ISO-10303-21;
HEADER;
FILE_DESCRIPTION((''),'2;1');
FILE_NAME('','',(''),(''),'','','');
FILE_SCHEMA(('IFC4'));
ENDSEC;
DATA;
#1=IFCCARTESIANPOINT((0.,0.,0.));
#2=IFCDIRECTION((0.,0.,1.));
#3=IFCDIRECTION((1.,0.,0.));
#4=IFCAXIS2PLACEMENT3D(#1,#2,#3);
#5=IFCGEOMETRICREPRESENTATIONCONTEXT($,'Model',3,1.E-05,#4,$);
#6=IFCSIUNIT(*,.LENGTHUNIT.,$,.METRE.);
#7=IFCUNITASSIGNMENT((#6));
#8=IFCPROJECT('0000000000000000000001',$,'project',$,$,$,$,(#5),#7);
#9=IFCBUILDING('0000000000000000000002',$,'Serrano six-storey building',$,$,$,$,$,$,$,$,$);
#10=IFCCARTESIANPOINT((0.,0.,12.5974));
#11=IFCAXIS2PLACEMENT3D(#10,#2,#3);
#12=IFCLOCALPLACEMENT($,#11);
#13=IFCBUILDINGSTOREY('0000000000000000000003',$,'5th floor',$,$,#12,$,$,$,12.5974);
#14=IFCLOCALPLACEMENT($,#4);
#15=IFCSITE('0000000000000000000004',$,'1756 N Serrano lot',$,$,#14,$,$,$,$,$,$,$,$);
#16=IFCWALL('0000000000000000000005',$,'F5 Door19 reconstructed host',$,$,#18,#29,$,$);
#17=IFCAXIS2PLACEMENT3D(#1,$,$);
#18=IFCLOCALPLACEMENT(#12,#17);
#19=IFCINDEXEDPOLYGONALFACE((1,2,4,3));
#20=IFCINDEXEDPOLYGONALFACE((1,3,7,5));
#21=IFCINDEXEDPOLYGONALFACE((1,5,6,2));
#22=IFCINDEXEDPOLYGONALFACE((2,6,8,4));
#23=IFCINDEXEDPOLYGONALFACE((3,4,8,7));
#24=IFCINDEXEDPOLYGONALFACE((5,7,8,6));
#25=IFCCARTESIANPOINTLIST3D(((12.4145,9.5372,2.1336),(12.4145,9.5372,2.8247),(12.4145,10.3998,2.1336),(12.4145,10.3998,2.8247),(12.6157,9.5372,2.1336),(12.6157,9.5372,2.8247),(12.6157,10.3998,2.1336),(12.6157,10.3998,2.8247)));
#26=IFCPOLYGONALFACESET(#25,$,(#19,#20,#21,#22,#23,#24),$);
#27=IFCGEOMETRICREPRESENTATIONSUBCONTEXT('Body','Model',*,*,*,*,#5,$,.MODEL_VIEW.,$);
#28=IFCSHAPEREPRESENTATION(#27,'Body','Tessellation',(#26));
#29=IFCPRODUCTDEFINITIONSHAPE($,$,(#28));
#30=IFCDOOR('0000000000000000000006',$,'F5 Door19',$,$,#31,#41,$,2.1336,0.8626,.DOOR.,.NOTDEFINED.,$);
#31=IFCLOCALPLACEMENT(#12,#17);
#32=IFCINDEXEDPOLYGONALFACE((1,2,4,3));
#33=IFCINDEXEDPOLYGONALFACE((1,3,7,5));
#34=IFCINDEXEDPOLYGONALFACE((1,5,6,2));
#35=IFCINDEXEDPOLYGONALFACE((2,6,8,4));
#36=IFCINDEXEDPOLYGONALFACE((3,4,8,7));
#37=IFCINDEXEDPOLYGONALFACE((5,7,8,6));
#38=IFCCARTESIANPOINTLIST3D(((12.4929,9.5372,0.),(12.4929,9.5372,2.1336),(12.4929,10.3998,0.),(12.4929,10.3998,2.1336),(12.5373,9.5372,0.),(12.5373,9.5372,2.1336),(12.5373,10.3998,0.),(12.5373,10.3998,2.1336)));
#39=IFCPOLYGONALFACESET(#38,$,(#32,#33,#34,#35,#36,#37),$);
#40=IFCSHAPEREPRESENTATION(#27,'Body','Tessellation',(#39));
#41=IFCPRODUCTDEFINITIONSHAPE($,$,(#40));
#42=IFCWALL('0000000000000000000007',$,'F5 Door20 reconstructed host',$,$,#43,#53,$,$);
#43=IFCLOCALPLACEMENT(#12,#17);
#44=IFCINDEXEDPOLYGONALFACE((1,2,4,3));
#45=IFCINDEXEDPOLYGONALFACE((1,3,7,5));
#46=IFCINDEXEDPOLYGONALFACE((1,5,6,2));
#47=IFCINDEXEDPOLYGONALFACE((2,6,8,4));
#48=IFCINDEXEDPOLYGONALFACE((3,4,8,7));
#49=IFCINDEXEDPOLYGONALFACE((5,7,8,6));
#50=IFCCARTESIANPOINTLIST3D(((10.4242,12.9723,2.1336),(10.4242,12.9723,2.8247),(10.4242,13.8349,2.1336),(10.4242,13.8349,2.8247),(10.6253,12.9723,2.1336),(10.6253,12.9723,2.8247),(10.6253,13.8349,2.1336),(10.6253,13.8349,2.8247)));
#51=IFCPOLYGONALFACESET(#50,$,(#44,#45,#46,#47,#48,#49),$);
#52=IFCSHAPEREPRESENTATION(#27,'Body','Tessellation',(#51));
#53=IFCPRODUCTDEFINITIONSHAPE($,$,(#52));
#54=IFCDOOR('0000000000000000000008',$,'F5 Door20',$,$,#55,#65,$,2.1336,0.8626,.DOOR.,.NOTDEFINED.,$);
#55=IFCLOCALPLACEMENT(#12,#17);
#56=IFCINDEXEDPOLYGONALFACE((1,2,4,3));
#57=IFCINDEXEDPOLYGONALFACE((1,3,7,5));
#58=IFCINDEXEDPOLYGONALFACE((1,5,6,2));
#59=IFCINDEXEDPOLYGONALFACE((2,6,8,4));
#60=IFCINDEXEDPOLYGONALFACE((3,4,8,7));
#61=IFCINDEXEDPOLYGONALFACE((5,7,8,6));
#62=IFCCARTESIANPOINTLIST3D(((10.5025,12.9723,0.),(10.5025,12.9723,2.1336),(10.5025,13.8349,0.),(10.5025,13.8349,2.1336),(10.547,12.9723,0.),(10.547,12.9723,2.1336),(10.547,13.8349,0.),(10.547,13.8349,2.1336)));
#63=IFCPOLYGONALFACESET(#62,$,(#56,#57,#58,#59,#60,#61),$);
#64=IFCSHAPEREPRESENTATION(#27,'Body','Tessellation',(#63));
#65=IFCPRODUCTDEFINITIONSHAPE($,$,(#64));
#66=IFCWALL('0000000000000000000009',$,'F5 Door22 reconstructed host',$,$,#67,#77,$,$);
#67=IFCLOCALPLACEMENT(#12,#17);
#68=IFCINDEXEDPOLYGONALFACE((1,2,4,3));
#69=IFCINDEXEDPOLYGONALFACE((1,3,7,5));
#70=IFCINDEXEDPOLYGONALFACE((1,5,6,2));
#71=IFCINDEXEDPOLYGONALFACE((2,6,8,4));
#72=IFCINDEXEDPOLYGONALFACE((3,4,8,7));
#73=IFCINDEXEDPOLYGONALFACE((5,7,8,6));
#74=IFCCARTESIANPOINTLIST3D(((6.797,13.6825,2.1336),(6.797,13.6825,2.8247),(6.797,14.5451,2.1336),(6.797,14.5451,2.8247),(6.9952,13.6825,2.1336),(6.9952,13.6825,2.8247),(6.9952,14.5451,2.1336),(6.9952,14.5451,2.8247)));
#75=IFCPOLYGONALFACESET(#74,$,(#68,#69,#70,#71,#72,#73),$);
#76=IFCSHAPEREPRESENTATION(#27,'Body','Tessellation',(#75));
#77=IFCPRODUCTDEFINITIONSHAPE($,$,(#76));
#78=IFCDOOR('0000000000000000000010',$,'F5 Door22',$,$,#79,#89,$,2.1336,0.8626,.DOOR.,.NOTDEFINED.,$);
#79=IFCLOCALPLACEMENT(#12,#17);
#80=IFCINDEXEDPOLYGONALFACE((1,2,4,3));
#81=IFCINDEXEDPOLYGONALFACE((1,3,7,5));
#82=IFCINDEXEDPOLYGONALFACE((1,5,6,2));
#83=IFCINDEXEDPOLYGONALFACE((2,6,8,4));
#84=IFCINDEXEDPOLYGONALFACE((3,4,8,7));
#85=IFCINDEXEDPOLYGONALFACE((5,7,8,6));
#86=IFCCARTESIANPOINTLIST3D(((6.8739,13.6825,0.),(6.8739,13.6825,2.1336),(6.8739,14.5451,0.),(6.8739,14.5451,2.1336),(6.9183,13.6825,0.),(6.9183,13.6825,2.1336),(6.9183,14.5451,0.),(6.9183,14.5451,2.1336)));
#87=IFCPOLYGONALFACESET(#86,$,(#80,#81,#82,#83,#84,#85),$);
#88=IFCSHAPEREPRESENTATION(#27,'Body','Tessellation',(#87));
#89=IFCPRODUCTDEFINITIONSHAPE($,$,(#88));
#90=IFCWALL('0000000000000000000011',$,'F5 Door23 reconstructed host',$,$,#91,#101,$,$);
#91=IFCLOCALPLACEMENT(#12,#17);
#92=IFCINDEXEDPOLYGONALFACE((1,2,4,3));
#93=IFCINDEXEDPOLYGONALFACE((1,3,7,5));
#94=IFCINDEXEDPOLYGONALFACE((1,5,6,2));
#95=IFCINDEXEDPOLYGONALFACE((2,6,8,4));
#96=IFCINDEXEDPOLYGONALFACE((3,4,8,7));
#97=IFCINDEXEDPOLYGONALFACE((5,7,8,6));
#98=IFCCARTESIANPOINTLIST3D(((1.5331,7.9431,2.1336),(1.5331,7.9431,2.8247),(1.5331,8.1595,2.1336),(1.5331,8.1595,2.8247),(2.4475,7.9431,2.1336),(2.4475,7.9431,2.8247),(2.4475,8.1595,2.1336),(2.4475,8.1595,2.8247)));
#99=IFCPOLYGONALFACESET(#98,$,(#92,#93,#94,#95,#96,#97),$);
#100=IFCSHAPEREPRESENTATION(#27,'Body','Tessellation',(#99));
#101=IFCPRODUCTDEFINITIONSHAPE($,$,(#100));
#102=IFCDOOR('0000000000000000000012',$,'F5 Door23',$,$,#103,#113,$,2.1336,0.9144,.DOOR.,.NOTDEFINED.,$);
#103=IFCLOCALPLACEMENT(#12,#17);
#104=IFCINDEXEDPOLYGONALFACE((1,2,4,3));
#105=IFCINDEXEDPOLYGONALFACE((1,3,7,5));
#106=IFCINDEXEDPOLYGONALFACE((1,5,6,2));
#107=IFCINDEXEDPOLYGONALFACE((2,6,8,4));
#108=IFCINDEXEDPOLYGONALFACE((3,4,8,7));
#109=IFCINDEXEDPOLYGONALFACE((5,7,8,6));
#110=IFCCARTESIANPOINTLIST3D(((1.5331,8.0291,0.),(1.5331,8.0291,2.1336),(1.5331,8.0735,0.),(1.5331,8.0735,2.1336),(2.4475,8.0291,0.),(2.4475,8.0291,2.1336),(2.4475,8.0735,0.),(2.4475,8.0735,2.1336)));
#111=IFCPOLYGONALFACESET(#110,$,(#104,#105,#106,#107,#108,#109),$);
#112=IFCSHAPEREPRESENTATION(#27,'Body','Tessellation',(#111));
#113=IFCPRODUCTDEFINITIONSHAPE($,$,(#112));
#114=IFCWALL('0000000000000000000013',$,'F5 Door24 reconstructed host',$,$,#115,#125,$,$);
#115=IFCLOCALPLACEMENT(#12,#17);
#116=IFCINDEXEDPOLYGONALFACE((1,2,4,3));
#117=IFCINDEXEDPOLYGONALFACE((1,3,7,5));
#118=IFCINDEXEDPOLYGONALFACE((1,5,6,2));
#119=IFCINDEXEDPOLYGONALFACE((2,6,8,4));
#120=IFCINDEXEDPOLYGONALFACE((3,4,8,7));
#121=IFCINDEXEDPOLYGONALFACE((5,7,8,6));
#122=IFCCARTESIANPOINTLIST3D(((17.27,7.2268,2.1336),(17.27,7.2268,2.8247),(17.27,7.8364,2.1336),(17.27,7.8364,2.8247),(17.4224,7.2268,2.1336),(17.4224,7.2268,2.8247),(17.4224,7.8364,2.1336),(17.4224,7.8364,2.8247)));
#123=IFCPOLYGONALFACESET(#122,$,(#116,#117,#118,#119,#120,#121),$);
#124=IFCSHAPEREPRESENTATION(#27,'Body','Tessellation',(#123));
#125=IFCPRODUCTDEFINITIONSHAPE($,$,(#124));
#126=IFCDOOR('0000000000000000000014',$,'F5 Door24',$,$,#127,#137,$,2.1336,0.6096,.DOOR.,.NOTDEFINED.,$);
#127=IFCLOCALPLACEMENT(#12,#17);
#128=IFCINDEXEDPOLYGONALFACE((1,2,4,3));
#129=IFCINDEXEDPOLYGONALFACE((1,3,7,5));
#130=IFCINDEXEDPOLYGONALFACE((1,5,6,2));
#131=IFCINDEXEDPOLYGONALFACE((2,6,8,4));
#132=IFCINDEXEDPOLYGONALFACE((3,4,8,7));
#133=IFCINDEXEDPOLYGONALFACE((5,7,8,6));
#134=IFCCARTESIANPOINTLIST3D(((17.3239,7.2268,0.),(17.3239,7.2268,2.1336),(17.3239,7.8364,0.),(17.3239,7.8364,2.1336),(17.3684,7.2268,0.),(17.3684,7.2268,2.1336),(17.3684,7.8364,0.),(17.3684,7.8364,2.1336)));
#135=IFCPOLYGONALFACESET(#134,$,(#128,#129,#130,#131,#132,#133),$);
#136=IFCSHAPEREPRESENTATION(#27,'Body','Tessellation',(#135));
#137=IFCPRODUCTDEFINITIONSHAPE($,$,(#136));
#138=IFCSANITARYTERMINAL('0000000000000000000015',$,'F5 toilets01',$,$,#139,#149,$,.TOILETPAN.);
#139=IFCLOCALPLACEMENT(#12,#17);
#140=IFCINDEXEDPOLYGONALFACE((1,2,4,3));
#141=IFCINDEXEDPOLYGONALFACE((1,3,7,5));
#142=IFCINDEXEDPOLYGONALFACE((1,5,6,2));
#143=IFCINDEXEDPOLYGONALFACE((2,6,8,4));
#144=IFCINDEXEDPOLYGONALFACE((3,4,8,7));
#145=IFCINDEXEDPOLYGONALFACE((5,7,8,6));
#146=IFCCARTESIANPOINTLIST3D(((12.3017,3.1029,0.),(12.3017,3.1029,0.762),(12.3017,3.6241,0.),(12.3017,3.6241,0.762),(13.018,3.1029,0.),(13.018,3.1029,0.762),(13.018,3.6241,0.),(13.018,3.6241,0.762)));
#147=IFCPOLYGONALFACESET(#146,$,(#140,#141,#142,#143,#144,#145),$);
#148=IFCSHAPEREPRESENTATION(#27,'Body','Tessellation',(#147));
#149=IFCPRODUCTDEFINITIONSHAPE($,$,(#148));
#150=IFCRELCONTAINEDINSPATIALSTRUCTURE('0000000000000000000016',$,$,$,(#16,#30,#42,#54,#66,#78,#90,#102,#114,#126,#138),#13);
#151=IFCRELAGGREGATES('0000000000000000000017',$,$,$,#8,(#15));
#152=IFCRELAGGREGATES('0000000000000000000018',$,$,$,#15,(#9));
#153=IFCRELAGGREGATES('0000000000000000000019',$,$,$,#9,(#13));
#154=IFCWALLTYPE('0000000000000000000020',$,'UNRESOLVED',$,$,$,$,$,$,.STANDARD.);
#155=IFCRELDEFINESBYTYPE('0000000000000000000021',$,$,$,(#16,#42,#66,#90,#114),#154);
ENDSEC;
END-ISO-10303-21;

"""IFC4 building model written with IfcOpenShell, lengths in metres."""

from ifc_helpers import new_model, si_unit, frame, origin_with_axes, place, context, subcontext, project, spatial, polyline, outline, extrude, type_object, element, fill, save


model = new_model("IFC4")

# Units and contexts
model_context = context("Model", 3, precision=1e-05, world=origin_with_axes())
body_context = subcontext(model_context, "Body", "Model", "MODEL_VIEW")
ifc_project = project(units=[si_unit("LENGTHUNIT", "METRE")], contexts=[model_context])

# Site, building, storey
site_placement = place(None, origin_with_axes())
site = spatial("IfcSite", under=ifc_project, at=site_placement, Name="1756 N Serrano lot")
building = spatial("IfcBuilding", under=site, Name="Serrano six-storey building")
storey_placement = place(None, frame((0.0, 0.0, 12.5974), z_axis=(0.0, 0.0, 1.0), x_axis=(1.0, 0.0, 0.0)))
storey = spatial("IfcBuildingStorey", under=building, at=storey_placement, Name="5th floor", Elevation=12.5974)

# Walls, openings, doors
wall_type_1 = type_object("IfcWallType", Name="UNRESOLVED", PredefinedType="STANDARD")
wall_1_placement = place(storey_placement, frame((0.0, 0.0, -12.5974), z_axis=(0.0, 0.0, 1.0), x_axis=(1.0, 0.0, 0.0)))
wall_1 = element("IfcWall", 1, at=wall_1_placement, inside=storey, type_object=wall_type_1, Name="F5 Door19 reconstructed host", context=body_context, shape_type="SweptSolid", body=[
    extrude(outline(polyline([(12.4145, 10.3998), (12.6157, 10.3998), (12.6157, 9.5372), (12.4145, 9.5372), (12.4145, 10.3998)])), frame((0.0, 0.0, 12.5974)), (0.0, 0.0, 1.0), 2.8247),
])
opening_1_placement = place(None, origin_with_axes())
opening_1 = element("IfcOpeningElement", 2, at=opening_1_placement, cuts=wall_1, PredefinedType="OPENING", context=body_context, shape_type="SweptSolid", body=[
    extrude(outline(polyline([(12.3962, 10.3998), (12.634, 10.3998), (12.634, 9.5372), (12.3962, 9.5372), (12.3962, 10.3998)])), frame((0.0, 0.0, 12.5974)), (0.0, 0.0, 1.0), 2.1336),
])
door_1_placement = place(storey_placement, frame((0.0, 0.0, -12.5974), z_axis=(0.0, 0.0, 1.0), x_axis=(1.0, 0.0, 0.0)))
door_1 = element("IfcDoor", 3, at=door_1_placement, inside=storey, Name="F5 Door19", OperationType="NOTDEFINED", OverallHeight=2.1336, OverallWidth=0.8626, PredefinedType="DOOR", context=body_context, shape_type="SweptSolid", body=[
    extrude(outline(polyline([(12.4929, 10.3998), (12.5373, 10.3998), (12.5373, 9.5372), (12.4929, 9.5372), (12.4929, 10.3998)])), frame((0.0, 0.0, 12.5974)), (0.0, 0.0, 1.0), 2.1336),
])
fill(opening_1, door_1)
wall_2_placement = place(storey_placement, frame((0.0, 0.0, -12.5974), z_axis=(0.0, 0.0, 1.0), x_axis=(1.0, 0.0, 0.0)))
wall_2 = element("IfcWall", 4, at=wall_2_placement, inside=storey, type_object=wall_type_1, Name="F5 Door20 reconstructed host", context=body_context, shape_type="SweptSolid", body=[
    extrude(outline(polyline([(10.6253, 12.9723), (10.4242, 12.9723), (10.4242, 13.8349), (10.6253, 13.8349), (10.6253, 12.9723)])), frame((0.0, 0.0, 12.5974)), (0.0, 0.0, 1.0), 2.8247),
])
opening_2_placement = place(None, origin_with_axes())
opening_2 = element("IfcOpeningElement", 5, at=opening_2_placement, cuts=wall_2, PredefinedType="OPENING", context=body_context, shape_type="SweptSolid", body=[
    extrude(outline(polyline([(10.6436, 12.9723), (10.4059, 12.9723), (10.4059, 13.8349), (10.6436, 13.8349), (10.6436, 12.9723)])), frame((0.0, 0.0, 12.5974)), (0.0, 0.0, 1.0), 2.1336),
])
door_2_placement = place(storey_placement, frame((0.0, 0.0, -12.5974), z_axis=(0.0, 0.0, 1.0), x_axis=(1.0, 0.0, 0.0)))
door_2 = element("IfcDoor", 6, at=door_2_placement, inside=storey, Name="F5 Door20", OperationType="NOTDEFINED", OverallHeight=2.1336, OverallWidth=0.8626, PredefinedType="DOOR", context=body_context, shape_type="SweptSolid", body=[
    extrude(outline(polyline([(10.547, 12.9723), (10.5025, 12.9723), (10.5025, 13.8349), (10.547, 13.8349), (10.547, 12.9723)])), frame((0.0, 0.0, 12.5974)), (0.0, 0.0, 1.0), 2.1336),
])
fill(opening_2, door_2)
wall_3_placement = place(storey_placement, frame((0.0, 0.0, -12.5974), z_axis=(0.0, 0.0, 1.0), x_axis=(1.0, 0.0, 0.0)))
wall_3 = element("IfcWall", 7, at=wall_3_placement, inside=storey, type_object=wall_type_1, Name="F5 Door22 reconstructed host", context=body_context, shape_type="SweptSolid", body=[
    extrude(outline(polyline([(6.9952, 13.6825), (6.797, 13.6825), (6.797, 14.5451), (6.9952, 14.5451), (6.9952, 13.6825)])), frame((0.0, 0.0, 12.5974)), (0.0, 0.0, 1.0), 2.8247),
])
opening_3_placement = place(None, origin_with_axes())
opening_3 = element("IfcOpeningElement", 8, at=opening_3_placement, cuts=wall_3, PredefinedType="OPENING", context=body_context, shape_type="SweptSolid", body=[
    extrude(outline(polyline([(7.0134, 13.6825), (6.7788, 13.6825), (6.7788, 14.5451), (7.0134, 14.5451), (7.0134, 13.6825)])), frame((0.0, 0.0, 12.5974)), (0.0, 0.0, 1.0), 2.1336),
])
door_3_placement = place(storey_placement, frame((0.0, 0.0, -12.5974), z_axis=(0.0, 0.0, 1.0), x_axis=(1.0, 0.0, 0.0)))
door_3 = element("IfcDoor", 9, at=door_3_placement, inside=storey, Name="F5 Door22", OperationType="NOTDEFINED", OverallHeight=2.1336, OverallWidth=0.8626, PredefinedType="DOOR", context=body_context, shape_type="SweptSolid", body=[
    extrude(outline(polyline([(6.9183, 13.6825), (6.8739, 13.6825), (6.8739, 14.5451), (6.9183, 14.5451), (6.9183, 13.6825)])), frame((0.0, 0.0, 12.5974)), (0.0, 0.0, 1.0), 2.1336),
])
fill(opening_3, door_3)
wall_4_placement = place(storey_placement, frame((0.0, 0.0, -12.5974), z_axis=(0.0, 0.0, 1.0), x_axis=(1.0, 0.0, 0.0)))
wall_4 = element("IfcWall", 10, at=wall_4_placement, inside=storey, type_object=wall_type_1, Name="F5 Door23 reconstructed host", context=body_context, shape_type="SweptSolid", body=[
    extrude(outline(polyline([(2.4475, 8.1595), (2.4475, 7.9431), (1.5331, 7.9431), (1.5331, 8.1595), (2.4475, 8.1595)])), frame((0.0, 0.0, 12.5974)), (0.0, 0.0, 1.0), 2.8247),
])
opening_4_placement = place(None, origin_with_axes())
opening_4 = element("IfcOpeningElement", 11, at=opening_4_placement, cuts=wall_4, PredefinedType="OPENING", context=body_context, shape_type="SweptSolid", body=[
    extrude(outline(polyline([(2.4475, 8.1778), (2.4475, 7.9248), (1.5331, 7.9248), (1.5331, 8.1778), (2.4475, 8.1778)])), frame((0.0, 0.0, 12.5974)), (0.0, 0.0, 1.0), 2.1336),
])
door_4_placement = place(storey_placement, frame((0.0, 0.0, -12.5974), z_axis=(0.0, 0.0, 1.0), x_axis=(1.0, 0.0, 0.0)))
door_4 = element("IfcDoor", 12, at=door_4_placement, inside=storey, Name="F5 Door23", OperationType="NOTDEFINED", OverallHeight=2.1336, OverallWidth=0.9144, PredefinedType="DOOR", context=body_context, shape_type="SweptSolid", body=[
    extrude(outline(polyline([(2.4475, 8.0735), (2.4475, 8.0291), (1.5331, 8.0291), (1.5331, 8.0735), (2.4475, 8.0735)])), frame((0.0, 0.0, 12.5974)), (0.0, 0.0, 1.0), 2.1336),
])
fill(opening_4, door_4)
wall_5_placement = place(storey_placement, frame((0.0, 0.0, -12.5974), z_axis=(0.0, 0.0, 1.0), x_axis=(1.0, 0.0, 0.0)))
wall_5 = element("IfcWall", 13, at=wall_5_placement, inside=storey, type_object=wall_type_1, Name="F5 Door24 reconstructed host", context=body_context, shape_type="SweptSolid", body=[
    extrude(outline(polyline([(17.27, 7.8364), (17.4224, 7.8364), (17.4224, 7.2268), (17.27, 7.2268), (17.27, 7.8364)])), frame((0.0, 0.0, 12.5974)), (0.0, 0.0, 1.0), 2.8247),
])
opening_5_placement = place(None, origin_with_axes())
opening_5 = element("IfcOpeningElement", 14, at=opening_5_placement, cuts=wall_5, PredefinedType="OPENING", context=body_context, shape_type="SweptSolid", body=[
    extrude(outline(polyline([(17.2517, 7.8364), (17.4407, 7.8364), (17.4407, 7.2268), (17.2517, 7.2268), (17.2517, 7.8364)])), frame((0.0, 0.0, 12.5974)), (0.0, 0.0, 1.0), 2.1336),
])
door_5_placement = place(storey_placement, frame((0.0, 0.0, -12.5974), z_axis=(0.0, 0.0, 1.0), x_axis=(1.0, 0.0, 0.0)))
door_5 = element("IfcDoor", 15, at=door_5_placement, inside=storey, Name="F5 Door24", OperationType="NOTDEFINED", OverallHeight=2.1336, OverallWidth=0.6096, PredefinedType="DOOR", context=body_context, shape_type="SweptSolid", body=[
    extrude(outline(polyline([(17.3239, 7.8364), (17.3684, 7.8364), (17.3684, 7.2268), (17.3239, 7.2268), (17.3239, 7.8364)])), frame((0.0, 0.0, 12.5974)), (0.0, 0.0, 1.0), 2.1336),
])
fill(opening_5, door_5)

# Sanitary terminal
sanitary_terminal_placement = place(storey_placement, frame((0.0, 0.0, -12.5974), z_axis=(0.0, 0.0, 1.0), x_axis=(1.0, 0.0, 0.0)))
element("IfcSanitaryTerminal", 16, at=sanitary_terminal_placement, inside=storey, Name="F5 toilets01", PredefinedType="TOILETPAN", context=body_context, shape_type="SweptSolid", body=[
    extrude(outline(polyline([(13.018, 3.1029), (13.018, 3.6241), (12.3017, 3.6241), (12.3017, 3.1029), (13.018, 3.1029)])), frame((0.0, 0.0, 12.5974)), (0.0, 0.0, 1.0), 0.762),
])

save(model, "model.ifc")
